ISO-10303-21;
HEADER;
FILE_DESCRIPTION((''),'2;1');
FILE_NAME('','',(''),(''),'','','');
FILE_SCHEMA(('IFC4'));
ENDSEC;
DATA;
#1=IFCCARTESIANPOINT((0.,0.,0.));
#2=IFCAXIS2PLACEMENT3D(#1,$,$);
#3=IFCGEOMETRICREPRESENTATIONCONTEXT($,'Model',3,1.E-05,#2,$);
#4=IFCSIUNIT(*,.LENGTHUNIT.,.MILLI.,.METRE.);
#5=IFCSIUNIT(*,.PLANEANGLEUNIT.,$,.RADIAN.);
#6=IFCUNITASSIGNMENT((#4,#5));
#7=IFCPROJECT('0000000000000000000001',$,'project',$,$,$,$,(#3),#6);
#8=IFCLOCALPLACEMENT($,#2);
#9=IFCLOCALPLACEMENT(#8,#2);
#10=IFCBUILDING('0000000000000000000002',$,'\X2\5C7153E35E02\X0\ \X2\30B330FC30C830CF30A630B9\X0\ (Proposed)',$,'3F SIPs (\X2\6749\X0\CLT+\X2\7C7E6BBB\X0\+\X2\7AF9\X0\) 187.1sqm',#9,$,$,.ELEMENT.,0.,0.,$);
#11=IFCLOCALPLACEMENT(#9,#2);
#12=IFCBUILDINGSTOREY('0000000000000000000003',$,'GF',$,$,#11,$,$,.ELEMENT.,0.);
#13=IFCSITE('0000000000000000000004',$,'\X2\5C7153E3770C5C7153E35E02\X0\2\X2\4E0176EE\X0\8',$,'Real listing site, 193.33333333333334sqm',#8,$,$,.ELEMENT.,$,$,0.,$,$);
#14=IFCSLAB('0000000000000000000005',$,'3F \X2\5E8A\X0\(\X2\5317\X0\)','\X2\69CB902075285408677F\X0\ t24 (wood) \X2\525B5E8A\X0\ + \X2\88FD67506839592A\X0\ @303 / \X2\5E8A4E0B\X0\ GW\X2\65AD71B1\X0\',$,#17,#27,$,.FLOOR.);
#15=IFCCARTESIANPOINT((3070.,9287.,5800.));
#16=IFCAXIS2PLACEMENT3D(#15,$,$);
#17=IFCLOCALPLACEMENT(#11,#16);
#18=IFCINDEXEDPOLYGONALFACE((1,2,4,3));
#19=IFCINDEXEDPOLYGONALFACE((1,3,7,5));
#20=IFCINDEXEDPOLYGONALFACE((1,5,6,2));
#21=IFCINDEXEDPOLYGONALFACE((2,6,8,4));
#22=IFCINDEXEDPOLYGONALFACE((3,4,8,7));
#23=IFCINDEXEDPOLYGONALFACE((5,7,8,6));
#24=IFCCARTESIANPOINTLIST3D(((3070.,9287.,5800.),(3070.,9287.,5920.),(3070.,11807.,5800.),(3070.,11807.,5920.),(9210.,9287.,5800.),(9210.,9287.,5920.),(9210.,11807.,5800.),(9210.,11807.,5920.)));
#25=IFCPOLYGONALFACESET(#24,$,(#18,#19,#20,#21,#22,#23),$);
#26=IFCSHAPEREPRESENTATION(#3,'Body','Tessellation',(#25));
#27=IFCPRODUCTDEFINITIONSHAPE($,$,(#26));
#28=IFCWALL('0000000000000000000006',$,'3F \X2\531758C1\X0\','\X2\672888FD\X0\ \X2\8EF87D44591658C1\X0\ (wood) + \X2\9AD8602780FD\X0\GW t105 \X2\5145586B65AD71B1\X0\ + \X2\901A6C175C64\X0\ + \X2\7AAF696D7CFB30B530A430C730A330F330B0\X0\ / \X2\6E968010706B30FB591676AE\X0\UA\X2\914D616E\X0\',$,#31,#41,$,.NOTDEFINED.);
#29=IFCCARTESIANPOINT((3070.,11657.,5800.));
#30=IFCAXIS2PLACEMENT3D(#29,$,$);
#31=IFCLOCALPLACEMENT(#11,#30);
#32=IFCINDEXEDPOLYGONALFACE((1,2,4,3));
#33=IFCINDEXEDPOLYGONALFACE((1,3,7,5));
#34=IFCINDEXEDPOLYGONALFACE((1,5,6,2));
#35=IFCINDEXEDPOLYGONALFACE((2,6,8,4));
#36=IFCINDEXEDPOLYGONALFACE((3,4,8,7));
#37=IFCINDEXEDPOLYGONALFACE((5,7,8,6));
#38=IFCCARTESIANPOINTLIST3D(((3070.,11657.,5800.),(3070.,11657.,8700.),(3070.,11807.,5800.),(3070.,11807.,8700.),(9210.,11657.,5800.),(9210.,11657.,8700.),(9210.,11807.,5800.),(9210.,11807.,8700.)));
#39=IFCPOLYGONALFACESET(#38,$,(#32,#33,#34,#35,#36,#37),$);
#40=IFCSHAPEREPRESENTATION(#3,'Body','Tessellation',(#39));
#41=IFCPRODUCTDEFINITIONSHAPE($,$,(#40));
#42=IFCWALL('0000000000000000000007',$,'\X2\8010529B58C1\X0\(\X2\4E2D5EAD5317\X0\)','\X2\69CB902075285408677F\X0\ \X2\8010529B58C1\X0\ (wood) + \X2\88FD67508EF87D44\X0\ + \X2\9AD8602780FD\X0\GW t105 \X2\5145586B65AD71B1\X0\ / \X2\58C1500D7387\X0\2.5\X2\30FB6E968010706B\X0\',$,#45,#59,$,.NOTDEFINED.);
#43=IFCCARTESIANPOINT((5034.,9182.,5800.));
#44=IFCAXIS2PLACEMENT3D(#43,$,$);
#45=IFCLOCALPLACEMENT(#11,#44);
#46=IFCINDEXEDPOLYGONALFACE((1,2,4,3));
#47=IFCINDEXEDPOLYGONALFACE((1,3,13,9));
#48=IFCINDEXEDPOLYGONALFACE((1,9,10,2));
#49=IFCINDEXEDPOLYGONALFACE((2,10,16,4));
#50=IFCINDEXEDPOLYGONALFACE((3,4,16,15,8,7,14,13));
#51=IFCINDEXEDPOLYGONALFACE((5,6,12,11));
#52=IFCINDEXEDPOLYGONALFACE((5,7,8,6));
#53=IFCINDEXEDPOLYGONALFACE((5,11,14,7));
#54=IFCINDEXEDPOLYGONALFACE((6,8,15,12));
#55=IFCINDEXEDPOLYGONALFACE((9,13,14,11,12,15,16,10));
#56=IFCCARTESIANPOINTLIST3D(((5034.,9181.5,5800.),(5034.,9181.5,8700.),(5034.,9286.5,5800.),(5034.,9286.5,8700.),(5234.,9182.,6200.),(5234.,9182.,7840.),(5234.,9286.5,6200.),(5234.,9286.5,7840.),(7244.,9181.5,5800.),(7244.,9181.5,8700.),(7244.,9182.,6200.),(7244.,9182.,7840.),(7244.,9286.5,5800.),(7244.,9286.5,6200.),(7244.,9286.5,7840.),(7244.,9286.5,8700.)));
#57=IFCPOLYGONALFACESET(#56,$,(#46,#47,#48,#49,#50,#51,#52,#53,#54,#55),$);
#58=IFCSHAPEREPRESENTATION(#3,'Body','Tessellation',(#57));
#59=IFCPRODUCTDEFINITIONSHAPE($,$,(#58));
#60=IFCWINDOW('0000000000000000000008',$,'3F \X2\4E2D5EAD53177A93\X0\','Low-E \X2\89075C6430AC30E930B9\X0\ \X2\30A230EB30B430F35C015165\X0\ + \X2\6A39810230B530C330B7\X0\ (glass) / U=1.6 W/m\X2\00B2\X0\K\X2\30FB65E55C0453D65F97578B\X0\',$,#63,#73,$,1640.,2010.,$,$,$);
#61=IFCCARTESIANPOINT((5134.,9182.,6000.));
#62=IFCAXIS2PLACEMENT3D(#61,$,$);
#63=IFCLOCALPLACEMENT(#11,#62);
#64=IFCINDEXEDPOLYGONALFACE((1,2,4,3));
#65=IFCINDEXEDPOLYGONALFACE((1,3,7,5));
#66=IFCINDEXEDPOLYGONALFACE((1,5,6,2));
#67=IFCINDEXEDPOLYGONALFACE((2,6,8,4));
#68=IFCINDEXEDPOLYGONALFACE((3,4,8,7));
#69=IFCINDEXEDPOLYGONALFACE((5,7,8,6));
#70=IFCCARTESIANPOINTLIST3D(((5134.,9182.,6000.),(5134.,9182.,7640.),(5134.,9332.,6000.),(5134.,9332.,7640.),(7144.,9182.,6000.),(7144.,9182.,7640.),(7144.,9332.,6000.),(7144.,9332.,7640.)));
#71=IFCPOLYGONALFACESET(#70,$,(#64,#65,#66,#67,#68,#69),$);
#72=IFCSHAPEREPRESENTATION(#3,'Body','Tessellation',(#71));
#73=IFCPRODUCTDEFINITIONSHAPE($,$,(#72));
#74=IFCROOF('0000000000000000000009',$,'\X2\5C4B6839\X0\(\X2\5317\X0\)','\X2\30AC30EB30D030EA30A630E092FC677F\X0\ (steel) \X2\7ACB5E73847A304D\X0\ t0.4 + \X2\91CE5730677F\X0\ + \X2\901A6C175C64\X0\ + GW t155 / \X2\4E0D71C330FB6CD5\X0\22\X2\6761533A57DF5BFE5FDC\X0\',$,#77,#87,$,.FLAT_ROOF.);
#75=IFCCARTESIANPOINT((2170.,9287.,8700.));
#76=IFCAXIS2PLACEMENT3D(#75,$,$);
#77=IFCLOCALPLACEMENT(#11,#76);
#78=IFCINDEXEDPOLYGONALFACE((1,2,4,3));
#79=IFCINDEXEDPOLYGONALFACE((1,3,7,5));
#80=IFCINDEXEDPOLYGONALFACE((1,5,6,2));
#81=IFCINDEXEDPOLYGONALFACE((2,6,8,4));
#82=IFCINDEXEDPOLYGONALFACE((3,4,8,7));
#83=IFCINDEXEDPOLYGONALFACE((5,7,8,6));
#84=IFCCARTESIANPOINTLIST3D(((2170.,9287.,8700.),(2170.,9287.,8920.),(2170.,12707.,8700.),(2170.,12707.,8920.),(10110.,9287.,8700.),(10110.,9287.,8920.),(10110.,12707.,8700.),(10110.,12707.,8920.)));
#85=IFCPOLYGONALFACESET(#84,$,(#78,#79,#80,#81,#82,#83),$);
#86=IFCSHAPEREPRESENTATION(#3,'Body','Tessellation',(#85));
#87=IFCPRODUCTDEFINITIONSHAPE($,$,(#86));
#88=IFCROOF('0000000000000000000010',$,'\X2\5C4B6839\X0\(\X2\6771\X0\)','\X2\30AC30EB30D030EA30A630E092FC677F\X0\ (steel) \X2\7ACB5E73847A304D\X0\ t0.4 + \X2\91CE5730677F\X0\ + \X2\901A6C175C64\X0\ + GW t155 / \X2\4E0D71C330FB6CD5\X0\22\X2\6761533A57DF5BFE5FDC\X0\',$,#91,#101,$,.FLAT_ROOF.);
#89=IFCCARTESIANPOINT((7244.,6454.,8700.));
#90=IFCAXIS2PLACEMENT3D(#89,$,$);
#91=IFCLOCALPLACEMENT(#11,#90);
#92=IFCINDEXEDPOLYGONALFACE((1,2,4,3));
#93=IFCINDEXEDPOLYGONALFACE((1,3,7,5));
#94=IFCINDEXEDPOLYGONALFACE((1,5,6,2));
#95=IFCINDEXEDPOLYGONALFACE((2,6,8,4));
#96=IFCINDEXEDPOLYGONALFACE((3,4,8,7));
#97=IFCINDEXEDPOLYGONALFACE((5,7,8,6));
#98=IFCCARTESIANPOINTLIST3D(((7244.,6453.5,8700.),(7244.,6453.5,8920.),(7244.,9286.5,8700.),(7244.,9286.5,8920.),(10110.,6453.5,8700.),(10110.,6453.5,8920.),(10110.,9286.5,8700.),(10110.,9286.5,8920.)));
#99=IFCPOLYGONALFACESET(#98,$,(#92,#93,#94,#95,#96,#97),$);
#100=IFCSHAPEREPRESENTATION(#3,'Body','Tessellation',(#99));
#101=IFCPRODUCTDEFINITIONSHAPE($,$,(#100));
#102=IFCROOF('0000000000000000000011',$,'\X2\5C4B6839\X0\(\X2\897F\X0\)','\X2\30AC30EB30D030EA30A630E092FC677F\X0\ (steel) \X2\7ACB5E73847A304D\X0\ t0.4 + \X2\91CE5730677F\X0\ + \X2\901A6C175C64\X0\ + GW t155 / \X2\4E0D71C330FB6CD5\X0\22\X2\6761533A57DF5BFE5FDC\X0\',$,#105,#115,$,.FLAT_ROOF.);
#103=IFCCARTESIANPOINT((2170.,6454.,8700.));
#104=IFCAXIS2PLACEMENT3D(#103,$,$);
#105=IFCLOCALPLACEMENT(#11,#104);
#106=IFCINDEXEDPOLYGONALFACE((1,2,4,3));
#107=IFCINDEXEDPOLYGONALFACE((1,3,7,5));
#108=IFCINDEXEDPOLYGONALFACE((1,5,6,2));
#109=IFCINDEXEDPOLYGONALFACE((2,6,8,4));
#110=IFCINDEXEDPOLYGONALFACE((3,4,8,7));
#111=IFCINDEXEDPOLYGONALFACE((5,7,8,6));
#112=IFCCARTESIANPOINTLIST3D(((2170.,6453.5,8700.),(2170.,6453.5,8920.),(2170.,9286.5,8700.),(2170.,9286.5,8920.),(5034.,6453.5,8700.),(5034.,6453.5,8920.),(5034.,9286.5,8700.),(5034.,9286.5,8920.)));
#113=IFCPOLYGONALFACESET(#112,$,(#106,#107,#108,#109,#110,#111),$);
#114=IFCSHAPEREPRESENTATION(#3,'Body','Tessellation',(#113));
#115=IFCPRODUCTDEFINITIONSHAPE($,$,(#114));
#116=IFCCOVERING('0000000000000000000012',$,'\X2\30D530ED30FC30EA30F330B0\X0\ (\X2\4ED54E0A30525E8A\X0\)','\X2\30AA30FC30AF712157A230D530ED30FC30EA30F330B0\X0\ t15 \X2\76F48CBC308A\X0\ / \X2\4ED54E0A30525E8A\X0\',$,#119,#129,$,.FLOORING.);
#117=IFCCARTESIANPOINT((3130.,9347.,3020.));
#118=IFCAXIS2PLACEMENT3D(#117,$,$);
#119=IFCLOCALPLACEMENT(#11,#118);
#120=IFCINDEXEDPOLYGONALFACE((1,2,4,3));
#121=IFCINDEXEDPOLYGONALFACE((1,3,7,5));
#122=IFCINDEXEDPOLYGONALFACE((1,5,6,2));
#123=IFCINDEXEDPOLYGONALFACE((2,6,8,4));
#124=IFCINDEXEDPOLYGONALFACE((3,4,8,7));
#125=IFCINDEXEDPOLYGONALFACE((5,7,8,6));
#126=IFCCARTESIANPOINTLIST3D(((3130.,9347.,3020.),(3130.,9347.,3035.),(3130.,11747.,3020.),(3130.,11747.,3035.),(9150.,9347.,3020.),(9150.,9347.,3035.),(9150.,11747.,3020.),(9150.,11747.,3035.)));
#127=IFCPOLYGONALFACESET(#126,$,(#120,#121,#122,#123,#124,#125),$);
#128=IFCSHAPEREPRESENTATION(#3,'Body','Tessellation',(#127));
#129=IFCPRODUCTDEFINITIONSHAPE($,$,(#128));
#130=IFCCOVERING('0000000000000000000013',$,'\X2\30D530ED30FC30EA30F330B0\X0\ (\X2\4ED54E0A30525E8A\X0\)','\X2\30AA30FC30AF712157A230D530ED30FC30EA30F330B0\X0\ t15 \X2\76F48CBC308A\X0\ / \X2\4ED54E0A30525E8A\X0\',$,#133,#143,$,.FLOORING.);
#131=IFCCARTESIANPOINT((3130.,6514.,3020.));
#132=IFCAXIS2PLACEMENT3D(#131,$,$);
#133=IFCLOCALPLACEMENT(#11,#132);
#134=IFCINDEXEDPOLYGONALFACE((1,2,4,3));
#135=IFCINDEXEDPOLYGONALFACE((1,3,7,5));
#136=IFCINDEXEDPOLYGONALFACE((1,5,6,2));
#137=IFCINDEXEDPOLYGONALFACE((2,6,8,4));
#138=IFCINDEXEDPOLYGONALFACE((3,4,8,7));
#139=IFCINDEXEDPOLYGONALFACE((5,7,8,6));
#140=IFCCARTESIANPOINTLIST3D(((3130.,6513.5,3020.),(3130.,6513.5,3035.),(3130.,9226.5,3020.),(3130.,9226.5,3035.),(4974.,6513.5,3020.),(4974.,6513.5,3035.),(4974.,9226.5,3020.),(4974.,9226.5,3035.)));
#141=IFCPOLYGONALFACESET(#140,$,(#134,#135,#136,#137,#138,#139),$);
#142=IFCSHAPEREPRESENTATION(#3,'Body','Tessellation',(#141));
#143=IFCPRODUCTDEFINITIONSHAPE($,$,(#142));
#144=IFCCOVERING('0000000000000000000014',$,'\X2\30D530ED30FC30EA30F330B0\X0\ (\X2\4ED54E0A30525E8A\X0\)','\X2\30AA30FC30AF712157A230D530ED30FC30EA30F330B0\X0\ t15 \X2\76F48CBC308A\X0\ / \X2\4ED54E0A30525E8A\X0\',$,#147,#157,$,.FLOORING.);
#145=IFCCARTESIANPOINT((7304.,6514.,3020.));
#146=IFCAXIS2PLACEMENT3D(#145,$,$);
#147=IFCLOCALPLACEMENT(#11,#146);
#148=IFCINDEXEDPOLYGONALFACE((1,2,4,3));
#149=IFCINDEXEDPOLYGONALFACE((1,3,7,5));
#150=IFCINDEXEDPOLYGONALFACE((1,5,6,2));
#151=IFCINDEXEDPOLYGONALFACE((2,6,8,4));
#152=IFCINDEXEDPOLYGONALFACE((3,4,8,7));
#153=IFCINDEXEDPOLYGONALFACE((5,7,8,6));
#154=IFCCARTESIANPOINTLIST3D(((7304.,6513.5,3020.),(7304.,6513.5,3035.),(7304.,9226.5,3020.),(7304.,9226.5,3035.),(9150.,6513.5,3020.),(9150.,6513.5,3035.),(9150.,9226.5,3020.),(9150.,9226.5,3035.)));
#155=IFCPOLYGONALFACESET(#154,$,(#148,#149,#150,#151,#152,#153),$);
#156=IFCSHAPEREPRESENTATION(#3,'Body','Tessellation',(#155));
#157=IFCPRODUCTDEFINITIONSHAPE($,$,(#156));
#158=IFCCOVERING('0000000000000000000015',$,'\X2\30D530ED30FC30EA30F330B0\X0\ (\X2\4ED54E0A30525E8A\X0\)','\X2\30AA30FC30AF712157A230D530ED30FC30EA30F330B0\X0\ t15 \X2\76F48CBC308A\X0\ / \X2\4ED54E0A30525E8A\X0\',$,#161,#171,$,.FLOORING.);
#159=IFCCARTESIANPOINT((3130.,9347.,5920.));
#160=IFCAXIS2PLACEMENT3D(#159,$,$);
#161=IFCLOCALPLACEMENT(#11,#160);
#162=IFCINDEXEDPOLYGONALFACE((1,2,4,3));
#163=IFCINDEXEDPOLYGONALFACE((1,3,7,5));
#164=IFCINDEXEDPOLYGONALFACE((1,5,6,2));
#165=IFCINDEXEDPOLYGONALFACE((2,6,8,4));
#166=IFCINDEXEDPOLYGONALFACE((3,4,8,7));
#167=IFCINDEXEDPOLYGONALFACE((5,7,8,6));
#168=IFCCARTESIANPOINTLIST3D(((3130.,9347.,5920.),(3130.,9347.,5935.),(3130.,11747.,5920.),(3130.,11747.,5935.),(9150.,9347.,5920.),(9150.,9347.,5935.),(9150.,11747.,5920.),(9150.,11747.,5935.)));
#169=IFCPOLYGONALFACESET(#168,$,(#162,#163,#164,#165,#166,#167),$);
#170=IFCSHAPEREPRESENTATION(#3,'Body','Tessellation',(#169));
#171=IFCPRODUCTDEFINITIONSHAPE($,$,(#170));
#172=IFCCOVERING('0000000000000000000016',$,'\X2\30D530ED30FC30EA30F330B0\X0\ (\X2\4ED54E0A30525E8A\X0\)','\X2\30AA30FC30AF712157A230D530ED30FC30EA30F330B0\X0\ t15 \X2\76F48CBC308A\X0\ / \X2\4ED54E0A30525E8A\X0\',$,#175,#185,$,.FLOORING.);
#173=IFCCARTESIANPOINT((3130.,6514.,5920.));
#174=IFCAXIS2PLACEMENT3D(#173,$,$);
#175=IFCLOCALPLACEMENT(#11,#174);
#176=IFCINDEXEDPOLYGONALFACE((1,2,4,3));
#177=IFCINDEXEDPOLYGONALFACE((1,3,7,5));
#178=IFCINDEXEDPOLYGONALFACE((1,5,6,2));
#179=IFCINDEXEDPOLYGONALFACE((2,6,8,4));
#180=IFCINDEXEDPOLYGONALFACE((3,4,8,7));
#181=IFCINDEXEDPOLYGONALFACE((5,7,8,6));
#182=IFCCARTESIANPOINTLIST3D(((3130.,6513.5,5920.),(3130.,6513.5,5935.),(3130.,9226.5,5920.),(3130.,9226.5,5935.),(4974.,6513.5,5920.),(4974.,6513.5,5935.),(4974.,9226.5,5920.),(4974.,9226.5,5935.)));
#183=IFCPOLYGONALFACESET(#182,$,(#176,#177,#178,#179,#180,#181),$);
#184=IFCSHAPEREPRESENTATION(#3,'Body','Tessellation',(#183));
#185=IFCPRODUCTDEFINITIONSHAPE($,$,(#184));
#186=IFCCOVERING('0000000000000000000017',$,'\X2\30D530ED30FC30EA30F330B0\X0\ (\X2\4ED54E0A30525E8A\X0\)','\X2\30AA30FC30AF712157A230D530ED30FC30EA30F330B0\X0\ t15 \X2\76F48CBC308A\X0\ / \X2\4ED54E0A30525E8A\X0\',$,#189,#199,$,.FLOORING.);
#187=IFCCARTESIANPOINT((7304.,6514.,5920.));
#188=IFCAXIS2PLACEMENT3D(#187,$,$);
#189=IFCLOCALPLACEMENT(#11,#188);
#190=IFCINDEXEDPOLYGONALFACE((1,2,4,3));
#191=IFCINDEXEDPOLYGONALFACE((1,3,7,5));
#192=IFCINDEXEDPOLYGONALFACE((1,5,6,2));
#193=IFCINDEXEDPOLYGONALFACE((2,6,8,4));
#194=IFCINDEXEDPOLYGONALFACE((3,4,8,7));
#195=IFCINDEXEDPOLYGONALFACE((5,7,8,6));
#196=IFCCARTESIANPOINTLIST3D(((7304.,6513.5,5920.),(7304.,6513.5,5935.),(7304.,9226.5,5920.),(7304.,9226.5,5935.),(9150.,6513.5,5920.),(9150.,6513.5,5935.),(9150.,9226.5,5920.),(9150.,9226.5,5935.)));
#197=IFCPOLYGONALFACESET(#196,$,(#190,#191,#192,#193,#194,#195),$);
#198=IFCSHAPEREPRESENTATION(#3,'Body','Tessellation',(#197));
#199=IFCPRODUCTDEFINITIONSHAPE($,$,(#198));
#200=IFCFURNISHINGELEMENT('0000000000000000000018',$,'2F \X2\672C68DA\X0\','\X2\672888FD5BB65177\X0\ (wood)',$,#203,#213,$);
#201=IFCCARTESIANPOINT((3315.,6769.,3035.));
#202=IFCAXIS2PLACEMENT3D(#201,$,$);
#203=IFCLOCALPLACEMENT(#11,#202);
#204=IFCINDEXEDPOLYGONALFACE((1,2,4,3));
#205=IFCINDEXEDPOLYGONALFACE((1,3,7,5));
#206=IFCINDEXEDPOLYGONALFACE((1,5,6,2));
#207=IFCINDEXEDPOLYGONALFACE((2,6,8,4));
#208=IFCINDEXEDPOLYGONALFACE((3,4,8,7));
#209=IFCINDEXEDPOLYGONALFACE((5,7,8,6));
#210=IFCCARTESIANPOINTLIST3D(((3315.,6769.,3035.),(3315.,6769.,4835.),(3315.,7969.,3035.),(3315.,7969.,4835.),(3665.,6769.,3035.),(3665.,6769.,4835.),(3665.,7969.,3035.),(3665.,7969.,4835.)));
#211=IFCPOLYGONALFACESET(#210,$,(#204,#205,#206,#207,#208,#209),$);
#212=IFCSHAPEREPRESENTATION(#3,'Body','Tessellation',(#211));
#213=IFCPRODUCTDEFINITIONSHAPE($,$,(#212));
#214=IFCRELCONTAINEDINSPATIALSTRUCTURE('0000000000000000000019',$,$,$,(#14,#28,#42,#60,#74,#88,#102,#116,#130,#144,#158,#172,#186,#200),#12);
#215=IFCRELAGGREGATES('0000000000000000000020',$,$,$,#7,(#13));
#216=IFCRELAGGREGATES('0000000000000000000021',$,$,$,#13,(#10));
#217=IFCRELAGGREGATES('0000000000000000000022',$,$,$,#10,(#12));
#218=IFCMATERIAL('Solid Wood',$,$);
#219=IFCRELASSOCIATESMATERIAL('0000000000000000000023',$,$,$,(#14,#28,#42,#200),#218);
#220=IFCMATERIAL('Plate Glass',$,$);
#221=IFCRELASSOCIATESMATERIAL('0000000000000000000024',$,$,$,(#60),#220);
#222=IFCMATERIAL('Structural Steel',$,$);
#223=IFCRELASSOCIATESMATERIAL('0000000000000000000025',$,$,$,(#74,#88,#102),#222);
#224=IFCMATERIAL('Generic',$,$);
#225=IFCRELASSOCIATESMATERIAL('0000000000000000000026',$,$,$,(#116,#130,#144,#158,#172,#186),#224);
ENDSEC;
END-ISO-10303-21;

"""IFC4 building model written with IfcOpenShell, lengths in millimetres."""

from ifc_helpers import new_model, si_unit, frame, frame_2d, origin, place, context, project, spatial, rectangle, extrude, material, element, fill, save


model = new_model("IFC4")

# Units and contexts
model_context = context("Model", 3, precision=1e-05, world=origin())
ifc_project = project(units=[si_unit("LENGTHUNIT", "METRE", prefix="MILLI"), si_unit("PLANEANGLEUNIT", "RADIAN")], contexts=[model_context])

# Site, building, storey
site_placement = place(None, origin())
site = spatial("IfcSite", under=ifc_project, at=site_placement, Name="山口県山口市2丁目8", ObjectType="Real listing site, 193.33333333333334sqm", CompositionType="ELEMENT", RefElevation=0.0)
building_placement = place(site_placement, origin())
building = spatial("IfcBuilding", under=site, at=building_placement, Name="山口市 コートハウス (Proposed)", ObjectType="3F SIPs (杉CLT+籾殻+竹) 187.1sqm", CompositionType="ELEMENT", ElevationOfRefHeight=0.0, ElevationOfTerrain=0.0)
storey_placement = place(building_placement, origin())
storey = spatial("IfcBuildingStorey", under=building, at=storey_placement, Name="GF", CompositionType="ELEMENT", Elevation=0.0)

# Slab
ifc_material_1 = material(Name="Solid Wood")
slab_placement = place(storey_placement, frame((3070.0, 9287.0, 5800.0)))
element("IfcSlab", 1, at=slab_placement, inside=storey, material=ifc_material_1, Name="3F 床(北)", Description="構造用合板 t24 (wood) 剛床 + 製材根太 @303 / 床下 GW断熱", PredefinedType="FLOOR", context=model_context, shape_type="SweptSolid", body=[
    extrude(rectangle(XDim=6140.0, YDim=2520.0, at=frame_2d((3070.0, 1260.0))), frame((3070.0, 9287.0, 5800.0)), (0.0, 0.0, 1.0), 120.0),
])

# Wall
wall_1_placement = place(storey_placement, frame((3070.0, 11657.0, 5800.0)))
element("IfcWall", 2, at=wall_1_placement, inside=storey, material=ifc_material_1, Name="3F 北壁", Description="木製 軸組外壁 (wood) + 高性能GW t105 充填断熱 + 通気層 + 窯業系サイディング / 準耐火・外皮UA配慮", PredefinedType="NOTDEFINED", context=model_context, shape_type="SweptSolid", body=[
    extrude(rectangle(XDim=6140.0, YDim=150.0, at=frame_2d((3070.0, 75.0))), frame((3070.0, 11657.0, 5800.0)), (0.0, 0.0, 1.0), 2900.0),
])

# Wall, opening, window
wall_2_placement = place(storey_placement, frame((5034.0, 9182.0, 5800.0)))
wall_2 = element("IfcWall", 3, at=wall_2_placement, inside=storey, material=ifc_material_1, Name="耐力壁(中庭北)", Description="構造用合板 耐力壁 (wood) + 製材軸組 + 高性能GW t105 充填断熱 / 壁倍率2.5・準耐火", PredefinedType="NOTDEFINED", context=model_context, shape_type="SweptSolid", body=[
    extrude(rectangle(XDim=2210.0, YDim=105.0, at=frame_2d((1105.0, 52.0))), frame((5034.0, 9182.0, 5800.0)), (0.0, 0.0, 1.0), 2900.0),
])
opening_placement = place(storey_placement, frame((5134.0, 9182.0, 6000.0)))
opening = element("IfcOpeningElement", 4, at=opening_placement, cuts=wall_2, PredefinedType="NOTDEFINED", context=model_context, shape_type="SweptSolid", body=[
    extrude(rectangle(XDim=2010.0, YDim=150.0, at=frame_2d((1005.0, 75.0))), frame((5134.0, 9182.0, 6000.0)), (0.0, 0.0, 1.0), 1640.0),
])
ifc_material_2 = material(Name="Plate Glass")
window_1_placement = place(storey_placement, frame((5134.0, 9182.0, 6000.0)))
window_1 = element("IfcWindow", 5, at=window_1_placement, inside=storey, material=ifc_material_2, Name="3F 中庭北窓", Description="Low-E 複層ガラス アルゴン封入 + 樹脂サッシ (glass) / U=1.6 W/m²K・日射取得型", OverallHeight=1640.0, OverallWidth=2010.0, context=model_context, shape_type="SweptSolid", body=[
    extrude(rectangle(XDim=2010.0, YDim=150.0, at=frame_2d((1005.0, 75.0))), frame((5134.0, 9182.0, 6000.0)), (0.0, 0.0, 1.0), 1640.0),
])
fill(opening, window_1)

# Shared definitions
ifc_material_3 = material(Name="Generic")

# Roofs
ifc_material_4 = material(Name="Structural Steel")
roof_1_placement = place(storey_placement, frame((2170.0, 9287.0, 8700.0)))
element("IfcRoof", 6, at=roof_1_placement, inside=storey, material=ifc_material_4, Name="屋根(北)", Description="ガルバリウム鋼板 (steel) 立平葺き t0.4 + 野地板 + 通気層 + GW t155 / 不燃・法22条区域対応", PredefinedType="FLAT_ROOF", context=model_context, shape_type="SweptSolid", body=[
    extrude(rectangle(XDim=7940.0, YDim=3420.0, at=frame_2d((3970.0, 1710.0))), frame((2170.0, 9287.0, 8700.0)), (0.0, 0.0, 1.0), 220.0),
])
roof_2_placement = place(storey_placement, frame((7244.0, 6454.0, 8700.0)))
element("IfcRoof", 7, at=roof_2_placement, inside=storey, material=ifc_material_4, Name="屋根(東)", Description="ガルバリウム鋼板 (steel) 立平葺き t0.4 + 野地板 + 通気層 + GW t155 / 不燃・法22条区域対応", PredefinedType="FLAT_ROOF", context=model_context, shape_type="SweptSolid", body=[
    extrude(rectangle(XDim=2866.0, YDim=2833.0, at=frame_2d((1433.0, 1416.0))), frame((7244.0, 6454.0, 8700.0)), (0.0, 0.0, 1.0), 220.0),
])
roof_3_placement = place(storey_placement, frame((2170.0, 6454.0, 8700.0)))
element("IfcRoof", 8, at=roof_3_placement, inside=storey, material=ifc_material_4, Name="屋根(西)", Description="ガルバリウム鋼板 (steel) 立平葺き t0.4 + 野地板 + 通気層 + GW t155 / 不燃・法22条区域対応", PredefinedType="FLAT_ROOF", context=model_context, shape_type="SweptSolid", body=[
    extrude(rectangle(XDim=2864.0, YDim=2833.0, at=frame_2d((1432.0, 1416.0))), frame((2170.0, 6454.0, 8700.0)), (0.0, 0.0, 1.0), 220.0),
])

# Coverings
covering_1_placement = place(storey_placement, frame((3130.0, 9347.0, 3020.0)))
element("IfcCovering", 9, at=covering_1_placement, inside=storey, material=ifc_material_3, Name="フローリング (仕上げ床)", Description="オーク無垢フローリング t15 直貼り / 仕上げ床", PredefinedType="FLOORING", context=model_context, shape_type="SweptSolid", body=[
    extrude(rectangle(XDim=6020.0, YDim=2400.0, at=frame_2d((3010.0, 1200.0))), frame((3130.0, 9347.0, 3020.0)), (0.0, 0.0, 1.0), 15.0),
])
covering_2_placement = place(storey_placement, frame((3130.0, 6514.0, 3020.0)))
element("IfcCovering", 10, at=covering_2_placement, inside=storey, material=ifc_material_3, Name="フローリング (仕上げ床)", Description="オーク無垢フローリング t15 直貼り / 仕上げ床", PredefinedType="FLOORING", context=model_context, shape_type="SweptSolid", body=[
    extrude(rectangle(XDim=1844.0, YDim=2713.0, at=frame_2d((922.0, 1356.0))), frame((3130.0, 6514.0, 3020.0)), (0.0, 0.0, 1.0), 15.0),
])
covering_3_placement = place(storey_placement, frame((7304.0, 6514.0, 3020.0)))
element("IfcCovering", 11, at=covering_3_placement, inside=storey, material=ifc_material_3, Name="フローリング (仕上げ床)", Description="オーク無垢フローリング t15 直貼り / 仕上げ床", PredefinedType="FLOORING", context=model_context, shape_type="SweptSolid", body=[
    extrude(rectangle(XDim=1846.0, YDim=2713.0, at=frame_2d((923.0, 1356.0))), frame((7304.0, 6514.0, 3020.0)), (0.0, 0.0, 1.0), 15.0),
])
covering_4_placement = place(storey_placement, frame((3130.0, 9347.0, 5920.0)))
element("IfcCovering", 12, at=covering_4_placement, inside=storey, material=ifc_material_3, Name="フローリング (仕上げ床)", Description="オーク無垢フローリング t15 直貼り / 仕上げ床", PredefinedType="FLOORING", context=model_context, shape_type="SweptSolid", body=[
    extrude(rectangle(XDim=6020.0, YDim=2400.0, at=frame_2d((3010.0, 1200.0))), frame((3130.0, 9347.0, 5920.0)), (0.0, 0.0, 1.0), 15.0),
])
covering_5_placement = place(storey_placement, frame((3130.0, 6514.0, 5920.0)))
element("IfcCovering", 13, at=covering_5_placement, inside=storey, material=ifc_material_3, Name="フローリング (仕上げ床)", Description="オーク無垢フローリング t15 直貼り / 仕上げ床", PredefinedType="FLOORING", context=model_context, shape_type="SweptSolid", body=[
    extrude(rectangle(XDim=1844.0, YDim=2713.0, at=frame_2d((922.0, 1356.0))), frame((3130.0, 6514.0, 5920.0)), (0.0, 0.0, 1.0), 15.0),
])
covering_6_placement = place(storey_placement, frame((7304.0, 6514.0, 5920.0)))
element("IfcCovering", 14, at=covering_6_placement, inside=storey, material=ifc_material_3, Name="フローリング (仕上げ床)", Description="オーク無垢フローリング t15 直貼り / 仕上げ床", PredefinedType="FLOORING", context=model_context, shape_type="SweptSolid", body=[
    extrude(rectangle(XDim=1846.0, YDim=2713.0, at=frame_2d((923.0, 1356.0))), frame((7304.0, 6514.0, 5920.0)), (0.0, 0.0, 1.0), 15.0),
])

# Furnishing element
furnishing_1_placement = place(storey_placement, frame((3315.0, 6769.0, 3035.0)))
element("IfcFurnishingElement", 15, at=furnishing_1_placement, inside=storey, material=ifc_material_1, Name="2F 本棚", Description="木製家具 (wood)", context=model_context, shape_type="SweptSolid", body=[
    extrude(rectangle(XDim=350.0, YDim=1200.0, at=frame_2d((175.0, 600.0))), frame((3315.0, 6769.0, 3035.0)), (0.0, 0.0, 1.0), 1800.0),
])

save(model, "model.ifc")
